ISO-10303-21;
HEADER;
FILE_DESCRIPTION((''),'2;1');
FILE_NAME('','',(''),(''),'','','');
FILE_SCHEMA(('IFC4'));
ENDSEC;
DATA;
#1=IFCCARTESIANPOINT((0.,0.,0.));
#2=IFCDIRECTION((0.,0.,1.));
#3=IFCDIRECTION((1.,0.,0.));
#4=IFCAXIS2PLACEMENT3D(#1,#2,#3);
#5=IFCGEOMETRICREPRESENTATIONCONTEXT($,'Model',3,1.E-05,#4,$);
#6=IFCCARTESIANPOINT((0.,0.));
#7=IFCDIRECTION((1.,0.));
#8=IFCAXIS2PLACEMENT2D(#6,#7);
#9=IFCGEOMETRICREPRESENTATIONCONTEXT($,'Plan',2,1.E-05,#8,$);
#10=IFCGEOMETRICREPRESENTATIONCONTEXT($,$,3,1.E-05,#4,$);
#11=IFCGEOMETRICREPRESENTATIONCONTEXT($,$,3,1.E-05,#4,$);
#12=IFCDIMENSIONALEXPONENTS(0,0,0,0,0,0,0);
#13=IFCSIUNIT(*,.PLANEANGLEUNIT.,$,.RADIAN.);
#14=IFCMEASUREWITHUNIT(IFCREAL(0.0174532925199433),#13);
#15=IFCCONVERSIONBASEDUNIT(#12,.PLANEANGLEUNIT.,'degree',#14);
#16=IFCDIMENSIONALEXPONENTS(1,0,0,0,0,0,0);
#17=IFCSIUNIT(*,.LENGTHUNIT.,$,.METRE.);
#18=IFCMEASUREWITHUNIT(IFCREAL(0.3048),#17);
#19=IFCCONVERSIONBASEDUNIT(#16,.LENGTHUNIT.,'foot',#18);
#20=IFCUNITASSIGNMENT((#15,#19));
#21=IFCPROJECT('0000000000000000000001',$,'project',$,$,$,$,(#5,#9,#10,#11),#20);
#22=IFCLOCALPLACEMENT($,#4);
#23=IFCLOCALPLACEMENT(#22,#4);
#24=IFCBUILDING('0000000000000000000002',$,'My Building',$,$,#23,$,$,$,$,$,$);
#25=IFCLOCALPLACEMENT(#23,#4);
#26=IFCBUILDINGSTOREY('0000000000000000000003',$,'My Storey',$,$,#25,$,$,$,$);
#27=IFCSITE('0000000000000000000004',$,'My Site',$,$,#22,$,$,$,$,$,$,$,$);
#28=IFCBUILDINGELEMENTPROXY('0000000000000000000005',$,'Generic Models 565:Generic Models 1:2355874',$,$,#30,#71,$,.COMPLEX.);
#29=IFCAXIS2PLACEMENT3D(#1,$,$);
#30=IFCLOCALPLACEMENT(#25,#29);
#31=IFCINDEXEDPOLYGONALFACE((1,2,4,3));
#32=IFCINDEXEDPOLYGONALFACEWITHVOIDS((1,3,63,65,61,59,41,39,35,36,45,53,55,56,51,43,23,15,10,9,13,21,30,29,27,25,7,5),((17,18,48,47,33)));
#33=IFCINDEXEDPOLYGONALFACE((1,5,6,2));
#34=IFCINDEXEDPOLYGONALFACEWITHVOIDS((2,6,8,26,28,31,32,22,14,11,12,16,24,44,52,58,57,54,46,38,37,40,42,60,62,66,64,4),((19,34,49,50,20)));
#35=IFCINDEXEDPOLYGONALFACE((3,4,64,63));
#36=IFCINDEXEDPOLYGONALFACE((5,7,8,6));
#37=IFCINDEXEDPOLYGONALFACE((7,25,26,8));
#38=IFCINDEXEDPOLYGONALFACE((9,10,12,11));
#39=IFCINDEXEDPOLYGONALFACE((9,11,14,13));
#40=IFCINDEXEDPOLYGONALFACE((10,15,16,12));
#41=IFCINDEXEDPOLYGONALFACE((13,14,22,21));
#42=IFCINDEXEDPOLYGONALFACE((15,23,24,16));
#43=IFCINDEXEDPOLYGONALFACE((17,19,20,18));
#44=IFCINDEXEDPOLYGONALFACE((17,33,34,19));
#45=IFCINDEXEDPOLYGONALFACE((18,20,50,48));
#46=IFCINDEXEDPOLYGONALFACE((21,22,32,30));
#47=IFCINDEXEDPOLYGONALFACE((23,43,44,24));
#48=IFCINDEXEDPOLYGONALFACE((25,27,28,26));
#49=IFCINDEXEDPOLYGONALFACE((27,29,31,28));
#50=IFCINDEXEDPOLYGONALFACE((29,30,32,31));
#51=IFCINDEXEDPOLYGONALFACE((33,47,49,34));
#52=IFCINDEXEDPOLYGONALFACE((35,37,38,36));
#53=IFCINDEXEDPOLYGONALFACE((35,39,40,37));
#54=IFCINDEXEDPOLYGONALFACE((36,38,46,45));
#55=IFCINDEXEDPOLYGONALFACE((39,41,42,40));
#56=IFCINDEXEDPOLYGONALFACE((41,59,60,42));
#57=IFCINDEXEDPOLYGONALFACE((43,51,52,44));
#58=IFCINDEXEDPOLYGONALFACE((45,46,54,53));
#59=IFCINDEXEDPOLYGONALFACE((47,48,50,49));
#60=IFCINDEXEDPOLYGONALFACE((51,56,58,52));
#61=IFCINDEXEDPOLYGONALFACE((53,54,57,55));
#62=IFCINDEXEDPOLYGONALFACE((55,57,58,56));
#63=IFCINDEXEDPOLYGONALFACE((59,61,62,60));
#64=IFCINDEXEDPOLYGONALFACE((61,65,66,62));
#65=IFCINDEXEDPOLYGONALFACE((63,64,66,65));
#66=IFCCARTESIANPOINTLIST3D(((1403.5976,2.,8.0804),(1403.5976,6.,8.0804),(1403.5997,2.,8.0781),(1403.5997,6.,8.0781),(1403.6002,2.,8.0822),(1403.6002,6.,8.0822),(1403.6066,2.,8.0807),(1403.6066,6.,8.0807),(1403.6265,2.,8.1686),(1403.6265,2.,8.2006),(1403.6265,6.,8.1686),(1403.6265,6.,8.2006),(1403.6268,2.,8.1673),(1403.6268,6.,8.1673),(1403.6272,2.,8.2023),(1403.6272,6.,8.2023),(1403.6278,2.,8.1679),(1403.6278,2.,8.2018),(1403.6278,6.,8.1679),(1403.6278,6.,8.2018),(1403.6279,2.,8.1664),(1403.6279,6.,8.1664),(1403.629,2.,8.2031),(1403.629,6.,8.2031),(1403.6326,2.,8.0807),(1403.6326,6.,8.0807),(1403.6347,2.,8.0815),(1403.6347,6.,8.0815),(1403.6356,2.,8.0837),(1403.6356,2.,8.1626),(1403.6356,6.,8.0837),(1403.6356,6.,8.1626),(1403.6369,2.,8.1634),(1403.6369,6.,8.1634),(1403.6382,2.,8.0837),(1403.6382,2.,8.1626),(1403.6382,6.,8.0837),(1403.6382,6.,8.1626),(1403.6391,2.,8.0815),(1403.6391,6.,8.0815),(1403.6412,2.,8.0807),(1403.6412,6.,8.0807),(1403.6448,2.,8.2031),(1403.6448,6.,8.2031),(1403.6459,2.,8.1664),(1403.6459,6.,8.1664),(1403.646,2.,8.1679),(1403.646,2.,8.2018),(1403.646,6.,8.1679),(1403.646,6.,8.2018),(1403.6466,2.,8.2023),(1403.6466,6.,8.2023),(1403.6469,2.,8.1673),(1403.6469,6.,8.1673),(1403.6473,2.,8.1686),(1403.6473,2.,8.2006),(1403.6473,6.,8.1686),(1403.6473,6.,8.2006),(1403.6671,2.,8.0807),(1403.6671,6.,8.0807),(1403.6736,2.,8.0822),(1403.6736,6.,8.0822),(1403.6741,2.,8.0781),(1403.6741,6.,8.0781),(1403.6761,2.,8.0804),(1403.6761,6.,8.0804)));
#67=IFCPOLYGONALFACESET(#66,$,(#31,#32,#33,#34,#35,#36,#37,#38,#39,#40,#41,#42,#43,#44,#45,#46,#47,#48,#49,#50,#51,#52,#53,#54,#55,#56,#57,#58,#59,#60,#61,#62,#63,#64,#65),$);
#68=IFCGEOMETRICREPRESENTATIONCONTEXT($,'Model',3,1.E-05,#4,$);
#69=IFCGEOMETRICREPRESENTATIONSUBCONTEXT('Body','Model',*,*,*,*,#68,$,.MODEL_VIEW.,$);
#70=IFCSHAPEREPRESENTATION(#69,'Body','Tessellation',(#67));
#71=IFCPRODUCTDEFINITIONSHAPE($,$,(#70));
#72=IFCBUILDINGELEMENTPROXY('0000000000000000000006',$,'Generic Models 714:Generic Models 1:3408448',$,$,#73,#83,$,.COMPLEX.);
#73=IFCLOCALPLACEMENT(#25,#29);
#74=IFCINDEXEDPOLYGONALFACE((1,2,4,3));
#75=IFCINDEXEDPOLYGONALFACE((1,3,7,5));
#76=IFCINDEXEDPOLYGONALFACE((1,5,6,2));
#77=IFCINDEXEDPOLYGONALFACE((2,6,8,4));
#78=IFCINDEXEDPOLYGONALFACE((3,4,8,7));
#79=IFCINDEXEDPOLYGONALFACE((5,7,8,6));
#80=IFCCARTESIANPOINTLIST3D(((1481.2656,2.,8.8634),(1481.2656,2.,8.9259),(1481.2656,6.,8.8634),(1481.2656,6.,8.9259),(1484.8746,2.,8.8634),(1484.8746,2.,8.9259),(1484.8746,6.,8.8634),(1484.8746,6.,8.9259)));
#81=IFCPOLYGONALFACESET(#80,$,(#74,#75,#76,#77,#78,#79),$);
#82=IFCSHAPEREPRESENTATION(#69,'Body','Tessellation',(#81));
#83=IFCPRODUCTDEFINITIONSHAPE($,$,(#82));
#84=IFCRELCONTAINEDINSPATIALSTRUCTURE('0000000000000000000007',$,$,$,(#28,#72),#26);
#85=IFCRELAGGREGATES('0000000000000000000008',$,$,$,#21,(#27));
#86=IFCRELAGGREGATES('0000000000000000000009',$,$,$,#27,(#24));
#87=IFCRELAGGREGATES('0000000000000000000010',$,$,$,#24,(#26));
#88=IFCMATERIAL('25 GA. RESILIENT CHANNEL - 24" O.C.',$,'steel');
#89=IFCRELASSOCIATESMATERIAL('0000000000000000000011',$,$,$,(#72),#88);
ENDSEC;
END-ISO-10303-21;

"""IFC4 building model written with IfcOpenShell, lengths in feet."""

from ifc_helpers import new_model, entity, si_unit, converted_unit, frame, origin_with_axes, origin_2d_with_axis, place, context, subcontext, project, spatial, polyline, line, indexed_curve, outline, extrude, material, element, save


model = new_model("IFC4")

# Units and contexts
model_context_1 = context("Model", 3, precision=1e-05, world=origin_with_axes())
plan_context = context("Plan", 2, precision=1e-05, world=origin_2d_with_axis())
model_context_2 = context("Model", 3, precision=1e-05, world=origin_with_axes())
context_of_model_1 = context(None, 3, precision=1e-05, world=origin_with_axes())
context_of_model_2 = context(None, 3, precision=1e-05, world=origin_with_axes())
body_context = subcontext(model_context_2, "Body", "Model", "MODEL_VIEW")
ifc_project = project(units=[converted_unit("PLANEANGLEUNIT", "degree", entity("IfcReal", 0.0174532925199433), si_unit("PLANEANGLEUNIT", "RADIAN"), dimensions=[0, 0, 0, 0, 0, 0, 0]), converted_unit("LENGTHUNIT", "foot", entity("IfcReal", 0.3048), si_unit("LENGTHUNIT", "METRE"), dimensions=[1, 0, 0, 0, 0, 0, 0])], contexts=[model_context_1, plan_context, context_of_model_1, context_of_model_2])

# Site, building, storey
site_placement = place(None, origin_with_axes())
site = spatial("IfcSite", under=ifc_project, at=site_placement, Name="My Site")
building_placement = place(site_placement, origin_with_axes())
building = spatial("IfcBuilding", under=site, at=building_placement, Name="My Building")
storey_placement = place(building_placement, origin_with_axes())
storey = spatial("IfcBuildingStorey", under=building, at=storey_placement, Name="My Storey")

# Building element proxies
proxy_1_placement = place(storey_placement, frame((1403.5976, 6.0, 8.0781), z_axis=(0.0, -1.0, 0.0), x_axis=(0.0, 0.0, 1.0)))
element("IfcBuildingElementProxy", 1, at=proxy_1_placement, inside=storey, Name="Generic Models 565:Generic Models 1:2355874", PredefinedType="COMPLEX", context=body_context, shape_type="SweptSolid", body=[
    extrude(outline(indexed_curve([(0.0297, 0.0058), (0.0311, 0.006), (0.0627, 0.0015), (0.0643, 0.0005), (0.0648, -0.0014), (0.0625, -0.017), (0.0615, -0.0187), (0.0597, -0.0192), (0.0281, -0.0146), (0.0268, -0.014), (0.0261, -0.0129), (0.0234, -0.0047), (-0.0547, 0.0066), (-0.0569, 0.006), (-0.0581, 0.0041), (-0.0618, -0.0216), (-0.0612, -0.0282), (-0.0634, -0.0305), (-0.0654, -0.0281), (-0.0547, 0.0455), (-0.0522, 0.0472), (-0.0507, 0.0444), (-0.0532, 0.0382), (-0.0569, 0.0126), (-0.0563, 0.0103), (-0.0543, 0.0092), (0.0238, -0.0021), (0.0286, 0.005), (0.0301, 0.0048), (0.0637, 0.0), (0.0611, -0.018), (0.0275, -0.0132), (0.0244, -0.0035)], segments=[line(7, 6), line(6, 5), line(5, 4), line(4, 3), line(3, 2), line(2, 1), line(1, 28), line(28, 27), line(27, 26), line(26, 25), line(25, 24), line(24, 23), line(23, 22), line(22, 21), line(21, 20), line(20, 19), line(19, 18), line(18, 17), line(17, 16), line(16, 15), line(15, 14), line(14, 13), line(13, 12), line(12, 11), line(11, 10), line(10, 9), line(9, 8), line(8, 7)], self_intersect=False), holes=[indexed_curve([(0.0297, 0.0058), (0.0311, 0.006), (0.0627, 0.0015), (0.0643, 0.0005), (0.0648, -0.0014), (0.0625, -0.017), (0.0615, -0.0187), (0.0597, -0.0192), (0.0281, -0.0146), (0.0268, -0.014), (0.0261, -0.0129), (0.0234, -0.0047), (-0.0547, 0.0066), (-0.0569, 0.006), (-0.0581, 0.0041), (-0.0618, -0.0216), (-0.0612, -0.0282), (-0.0634, -0.0305), (-0.0654, -0.0281), (-0.0547, 0.0455), (-0.0522, 0.0472), (-0.0507, 0.0444), (-0.0532, 0.0382), (-0.0569, 0.0126), (-0.0563, 0.0103), (-0.0543, 0.0092), (0.0238, -0.0021), (0.0286, 0.005), (0.0301, 0.0048), (0.0637, 0.0), (0.0611, -0.018), (0.0275, -0.0132), (0.0244, -0.0035)], segments=[line(31, 32), line(32, 33), line(33, 29), line(29, 30), line(30, 31)], self_intersect=False)]), frame((0.0607, -0.0392, 0.0), z_axis=(0.0, 0.0, -1.0), x_axis=(0.989698, -0.14317, 0.0)), (0.0, 0.0, -1.0), 4.0),
])
ifc_material_1 = material(Name="25 GA. RESILIENT CHANNEL - 24\" O.C.", Category="steel")
proxy_2_placement = place(storey_placement, frame((1481.263, 6.0, 8.8634), z_axis=(0.0, -1.0, 0.0), x_axis=(0.0, 0.0, 1.0)))
element("IfcBuildingElementProxy", 2, at=proxy_2_placement, inside=storey, material=ifc_material_1, Name="Generic Models 714:Generic Models 1:3408448", PredefinedType="COMPLEX", context=body_context, shape_type="SweptSolid", body=[
    extrude(outline(polyline([(-0.0313, -1.8045), (0.0312, -1.8045), (0.0313, 1.8045), (-0.0312, 1.8045), (-0.0313, -1.8045)])), frame((0.0313, -1.8072, 0.0), z_axis=(0.0, 0.0, -1.0), x_axis=(-1.0, 0.0, 0.0)), (0.0, 0.0, -1.0), 4.0),
])

save(model, "model.ifc")
